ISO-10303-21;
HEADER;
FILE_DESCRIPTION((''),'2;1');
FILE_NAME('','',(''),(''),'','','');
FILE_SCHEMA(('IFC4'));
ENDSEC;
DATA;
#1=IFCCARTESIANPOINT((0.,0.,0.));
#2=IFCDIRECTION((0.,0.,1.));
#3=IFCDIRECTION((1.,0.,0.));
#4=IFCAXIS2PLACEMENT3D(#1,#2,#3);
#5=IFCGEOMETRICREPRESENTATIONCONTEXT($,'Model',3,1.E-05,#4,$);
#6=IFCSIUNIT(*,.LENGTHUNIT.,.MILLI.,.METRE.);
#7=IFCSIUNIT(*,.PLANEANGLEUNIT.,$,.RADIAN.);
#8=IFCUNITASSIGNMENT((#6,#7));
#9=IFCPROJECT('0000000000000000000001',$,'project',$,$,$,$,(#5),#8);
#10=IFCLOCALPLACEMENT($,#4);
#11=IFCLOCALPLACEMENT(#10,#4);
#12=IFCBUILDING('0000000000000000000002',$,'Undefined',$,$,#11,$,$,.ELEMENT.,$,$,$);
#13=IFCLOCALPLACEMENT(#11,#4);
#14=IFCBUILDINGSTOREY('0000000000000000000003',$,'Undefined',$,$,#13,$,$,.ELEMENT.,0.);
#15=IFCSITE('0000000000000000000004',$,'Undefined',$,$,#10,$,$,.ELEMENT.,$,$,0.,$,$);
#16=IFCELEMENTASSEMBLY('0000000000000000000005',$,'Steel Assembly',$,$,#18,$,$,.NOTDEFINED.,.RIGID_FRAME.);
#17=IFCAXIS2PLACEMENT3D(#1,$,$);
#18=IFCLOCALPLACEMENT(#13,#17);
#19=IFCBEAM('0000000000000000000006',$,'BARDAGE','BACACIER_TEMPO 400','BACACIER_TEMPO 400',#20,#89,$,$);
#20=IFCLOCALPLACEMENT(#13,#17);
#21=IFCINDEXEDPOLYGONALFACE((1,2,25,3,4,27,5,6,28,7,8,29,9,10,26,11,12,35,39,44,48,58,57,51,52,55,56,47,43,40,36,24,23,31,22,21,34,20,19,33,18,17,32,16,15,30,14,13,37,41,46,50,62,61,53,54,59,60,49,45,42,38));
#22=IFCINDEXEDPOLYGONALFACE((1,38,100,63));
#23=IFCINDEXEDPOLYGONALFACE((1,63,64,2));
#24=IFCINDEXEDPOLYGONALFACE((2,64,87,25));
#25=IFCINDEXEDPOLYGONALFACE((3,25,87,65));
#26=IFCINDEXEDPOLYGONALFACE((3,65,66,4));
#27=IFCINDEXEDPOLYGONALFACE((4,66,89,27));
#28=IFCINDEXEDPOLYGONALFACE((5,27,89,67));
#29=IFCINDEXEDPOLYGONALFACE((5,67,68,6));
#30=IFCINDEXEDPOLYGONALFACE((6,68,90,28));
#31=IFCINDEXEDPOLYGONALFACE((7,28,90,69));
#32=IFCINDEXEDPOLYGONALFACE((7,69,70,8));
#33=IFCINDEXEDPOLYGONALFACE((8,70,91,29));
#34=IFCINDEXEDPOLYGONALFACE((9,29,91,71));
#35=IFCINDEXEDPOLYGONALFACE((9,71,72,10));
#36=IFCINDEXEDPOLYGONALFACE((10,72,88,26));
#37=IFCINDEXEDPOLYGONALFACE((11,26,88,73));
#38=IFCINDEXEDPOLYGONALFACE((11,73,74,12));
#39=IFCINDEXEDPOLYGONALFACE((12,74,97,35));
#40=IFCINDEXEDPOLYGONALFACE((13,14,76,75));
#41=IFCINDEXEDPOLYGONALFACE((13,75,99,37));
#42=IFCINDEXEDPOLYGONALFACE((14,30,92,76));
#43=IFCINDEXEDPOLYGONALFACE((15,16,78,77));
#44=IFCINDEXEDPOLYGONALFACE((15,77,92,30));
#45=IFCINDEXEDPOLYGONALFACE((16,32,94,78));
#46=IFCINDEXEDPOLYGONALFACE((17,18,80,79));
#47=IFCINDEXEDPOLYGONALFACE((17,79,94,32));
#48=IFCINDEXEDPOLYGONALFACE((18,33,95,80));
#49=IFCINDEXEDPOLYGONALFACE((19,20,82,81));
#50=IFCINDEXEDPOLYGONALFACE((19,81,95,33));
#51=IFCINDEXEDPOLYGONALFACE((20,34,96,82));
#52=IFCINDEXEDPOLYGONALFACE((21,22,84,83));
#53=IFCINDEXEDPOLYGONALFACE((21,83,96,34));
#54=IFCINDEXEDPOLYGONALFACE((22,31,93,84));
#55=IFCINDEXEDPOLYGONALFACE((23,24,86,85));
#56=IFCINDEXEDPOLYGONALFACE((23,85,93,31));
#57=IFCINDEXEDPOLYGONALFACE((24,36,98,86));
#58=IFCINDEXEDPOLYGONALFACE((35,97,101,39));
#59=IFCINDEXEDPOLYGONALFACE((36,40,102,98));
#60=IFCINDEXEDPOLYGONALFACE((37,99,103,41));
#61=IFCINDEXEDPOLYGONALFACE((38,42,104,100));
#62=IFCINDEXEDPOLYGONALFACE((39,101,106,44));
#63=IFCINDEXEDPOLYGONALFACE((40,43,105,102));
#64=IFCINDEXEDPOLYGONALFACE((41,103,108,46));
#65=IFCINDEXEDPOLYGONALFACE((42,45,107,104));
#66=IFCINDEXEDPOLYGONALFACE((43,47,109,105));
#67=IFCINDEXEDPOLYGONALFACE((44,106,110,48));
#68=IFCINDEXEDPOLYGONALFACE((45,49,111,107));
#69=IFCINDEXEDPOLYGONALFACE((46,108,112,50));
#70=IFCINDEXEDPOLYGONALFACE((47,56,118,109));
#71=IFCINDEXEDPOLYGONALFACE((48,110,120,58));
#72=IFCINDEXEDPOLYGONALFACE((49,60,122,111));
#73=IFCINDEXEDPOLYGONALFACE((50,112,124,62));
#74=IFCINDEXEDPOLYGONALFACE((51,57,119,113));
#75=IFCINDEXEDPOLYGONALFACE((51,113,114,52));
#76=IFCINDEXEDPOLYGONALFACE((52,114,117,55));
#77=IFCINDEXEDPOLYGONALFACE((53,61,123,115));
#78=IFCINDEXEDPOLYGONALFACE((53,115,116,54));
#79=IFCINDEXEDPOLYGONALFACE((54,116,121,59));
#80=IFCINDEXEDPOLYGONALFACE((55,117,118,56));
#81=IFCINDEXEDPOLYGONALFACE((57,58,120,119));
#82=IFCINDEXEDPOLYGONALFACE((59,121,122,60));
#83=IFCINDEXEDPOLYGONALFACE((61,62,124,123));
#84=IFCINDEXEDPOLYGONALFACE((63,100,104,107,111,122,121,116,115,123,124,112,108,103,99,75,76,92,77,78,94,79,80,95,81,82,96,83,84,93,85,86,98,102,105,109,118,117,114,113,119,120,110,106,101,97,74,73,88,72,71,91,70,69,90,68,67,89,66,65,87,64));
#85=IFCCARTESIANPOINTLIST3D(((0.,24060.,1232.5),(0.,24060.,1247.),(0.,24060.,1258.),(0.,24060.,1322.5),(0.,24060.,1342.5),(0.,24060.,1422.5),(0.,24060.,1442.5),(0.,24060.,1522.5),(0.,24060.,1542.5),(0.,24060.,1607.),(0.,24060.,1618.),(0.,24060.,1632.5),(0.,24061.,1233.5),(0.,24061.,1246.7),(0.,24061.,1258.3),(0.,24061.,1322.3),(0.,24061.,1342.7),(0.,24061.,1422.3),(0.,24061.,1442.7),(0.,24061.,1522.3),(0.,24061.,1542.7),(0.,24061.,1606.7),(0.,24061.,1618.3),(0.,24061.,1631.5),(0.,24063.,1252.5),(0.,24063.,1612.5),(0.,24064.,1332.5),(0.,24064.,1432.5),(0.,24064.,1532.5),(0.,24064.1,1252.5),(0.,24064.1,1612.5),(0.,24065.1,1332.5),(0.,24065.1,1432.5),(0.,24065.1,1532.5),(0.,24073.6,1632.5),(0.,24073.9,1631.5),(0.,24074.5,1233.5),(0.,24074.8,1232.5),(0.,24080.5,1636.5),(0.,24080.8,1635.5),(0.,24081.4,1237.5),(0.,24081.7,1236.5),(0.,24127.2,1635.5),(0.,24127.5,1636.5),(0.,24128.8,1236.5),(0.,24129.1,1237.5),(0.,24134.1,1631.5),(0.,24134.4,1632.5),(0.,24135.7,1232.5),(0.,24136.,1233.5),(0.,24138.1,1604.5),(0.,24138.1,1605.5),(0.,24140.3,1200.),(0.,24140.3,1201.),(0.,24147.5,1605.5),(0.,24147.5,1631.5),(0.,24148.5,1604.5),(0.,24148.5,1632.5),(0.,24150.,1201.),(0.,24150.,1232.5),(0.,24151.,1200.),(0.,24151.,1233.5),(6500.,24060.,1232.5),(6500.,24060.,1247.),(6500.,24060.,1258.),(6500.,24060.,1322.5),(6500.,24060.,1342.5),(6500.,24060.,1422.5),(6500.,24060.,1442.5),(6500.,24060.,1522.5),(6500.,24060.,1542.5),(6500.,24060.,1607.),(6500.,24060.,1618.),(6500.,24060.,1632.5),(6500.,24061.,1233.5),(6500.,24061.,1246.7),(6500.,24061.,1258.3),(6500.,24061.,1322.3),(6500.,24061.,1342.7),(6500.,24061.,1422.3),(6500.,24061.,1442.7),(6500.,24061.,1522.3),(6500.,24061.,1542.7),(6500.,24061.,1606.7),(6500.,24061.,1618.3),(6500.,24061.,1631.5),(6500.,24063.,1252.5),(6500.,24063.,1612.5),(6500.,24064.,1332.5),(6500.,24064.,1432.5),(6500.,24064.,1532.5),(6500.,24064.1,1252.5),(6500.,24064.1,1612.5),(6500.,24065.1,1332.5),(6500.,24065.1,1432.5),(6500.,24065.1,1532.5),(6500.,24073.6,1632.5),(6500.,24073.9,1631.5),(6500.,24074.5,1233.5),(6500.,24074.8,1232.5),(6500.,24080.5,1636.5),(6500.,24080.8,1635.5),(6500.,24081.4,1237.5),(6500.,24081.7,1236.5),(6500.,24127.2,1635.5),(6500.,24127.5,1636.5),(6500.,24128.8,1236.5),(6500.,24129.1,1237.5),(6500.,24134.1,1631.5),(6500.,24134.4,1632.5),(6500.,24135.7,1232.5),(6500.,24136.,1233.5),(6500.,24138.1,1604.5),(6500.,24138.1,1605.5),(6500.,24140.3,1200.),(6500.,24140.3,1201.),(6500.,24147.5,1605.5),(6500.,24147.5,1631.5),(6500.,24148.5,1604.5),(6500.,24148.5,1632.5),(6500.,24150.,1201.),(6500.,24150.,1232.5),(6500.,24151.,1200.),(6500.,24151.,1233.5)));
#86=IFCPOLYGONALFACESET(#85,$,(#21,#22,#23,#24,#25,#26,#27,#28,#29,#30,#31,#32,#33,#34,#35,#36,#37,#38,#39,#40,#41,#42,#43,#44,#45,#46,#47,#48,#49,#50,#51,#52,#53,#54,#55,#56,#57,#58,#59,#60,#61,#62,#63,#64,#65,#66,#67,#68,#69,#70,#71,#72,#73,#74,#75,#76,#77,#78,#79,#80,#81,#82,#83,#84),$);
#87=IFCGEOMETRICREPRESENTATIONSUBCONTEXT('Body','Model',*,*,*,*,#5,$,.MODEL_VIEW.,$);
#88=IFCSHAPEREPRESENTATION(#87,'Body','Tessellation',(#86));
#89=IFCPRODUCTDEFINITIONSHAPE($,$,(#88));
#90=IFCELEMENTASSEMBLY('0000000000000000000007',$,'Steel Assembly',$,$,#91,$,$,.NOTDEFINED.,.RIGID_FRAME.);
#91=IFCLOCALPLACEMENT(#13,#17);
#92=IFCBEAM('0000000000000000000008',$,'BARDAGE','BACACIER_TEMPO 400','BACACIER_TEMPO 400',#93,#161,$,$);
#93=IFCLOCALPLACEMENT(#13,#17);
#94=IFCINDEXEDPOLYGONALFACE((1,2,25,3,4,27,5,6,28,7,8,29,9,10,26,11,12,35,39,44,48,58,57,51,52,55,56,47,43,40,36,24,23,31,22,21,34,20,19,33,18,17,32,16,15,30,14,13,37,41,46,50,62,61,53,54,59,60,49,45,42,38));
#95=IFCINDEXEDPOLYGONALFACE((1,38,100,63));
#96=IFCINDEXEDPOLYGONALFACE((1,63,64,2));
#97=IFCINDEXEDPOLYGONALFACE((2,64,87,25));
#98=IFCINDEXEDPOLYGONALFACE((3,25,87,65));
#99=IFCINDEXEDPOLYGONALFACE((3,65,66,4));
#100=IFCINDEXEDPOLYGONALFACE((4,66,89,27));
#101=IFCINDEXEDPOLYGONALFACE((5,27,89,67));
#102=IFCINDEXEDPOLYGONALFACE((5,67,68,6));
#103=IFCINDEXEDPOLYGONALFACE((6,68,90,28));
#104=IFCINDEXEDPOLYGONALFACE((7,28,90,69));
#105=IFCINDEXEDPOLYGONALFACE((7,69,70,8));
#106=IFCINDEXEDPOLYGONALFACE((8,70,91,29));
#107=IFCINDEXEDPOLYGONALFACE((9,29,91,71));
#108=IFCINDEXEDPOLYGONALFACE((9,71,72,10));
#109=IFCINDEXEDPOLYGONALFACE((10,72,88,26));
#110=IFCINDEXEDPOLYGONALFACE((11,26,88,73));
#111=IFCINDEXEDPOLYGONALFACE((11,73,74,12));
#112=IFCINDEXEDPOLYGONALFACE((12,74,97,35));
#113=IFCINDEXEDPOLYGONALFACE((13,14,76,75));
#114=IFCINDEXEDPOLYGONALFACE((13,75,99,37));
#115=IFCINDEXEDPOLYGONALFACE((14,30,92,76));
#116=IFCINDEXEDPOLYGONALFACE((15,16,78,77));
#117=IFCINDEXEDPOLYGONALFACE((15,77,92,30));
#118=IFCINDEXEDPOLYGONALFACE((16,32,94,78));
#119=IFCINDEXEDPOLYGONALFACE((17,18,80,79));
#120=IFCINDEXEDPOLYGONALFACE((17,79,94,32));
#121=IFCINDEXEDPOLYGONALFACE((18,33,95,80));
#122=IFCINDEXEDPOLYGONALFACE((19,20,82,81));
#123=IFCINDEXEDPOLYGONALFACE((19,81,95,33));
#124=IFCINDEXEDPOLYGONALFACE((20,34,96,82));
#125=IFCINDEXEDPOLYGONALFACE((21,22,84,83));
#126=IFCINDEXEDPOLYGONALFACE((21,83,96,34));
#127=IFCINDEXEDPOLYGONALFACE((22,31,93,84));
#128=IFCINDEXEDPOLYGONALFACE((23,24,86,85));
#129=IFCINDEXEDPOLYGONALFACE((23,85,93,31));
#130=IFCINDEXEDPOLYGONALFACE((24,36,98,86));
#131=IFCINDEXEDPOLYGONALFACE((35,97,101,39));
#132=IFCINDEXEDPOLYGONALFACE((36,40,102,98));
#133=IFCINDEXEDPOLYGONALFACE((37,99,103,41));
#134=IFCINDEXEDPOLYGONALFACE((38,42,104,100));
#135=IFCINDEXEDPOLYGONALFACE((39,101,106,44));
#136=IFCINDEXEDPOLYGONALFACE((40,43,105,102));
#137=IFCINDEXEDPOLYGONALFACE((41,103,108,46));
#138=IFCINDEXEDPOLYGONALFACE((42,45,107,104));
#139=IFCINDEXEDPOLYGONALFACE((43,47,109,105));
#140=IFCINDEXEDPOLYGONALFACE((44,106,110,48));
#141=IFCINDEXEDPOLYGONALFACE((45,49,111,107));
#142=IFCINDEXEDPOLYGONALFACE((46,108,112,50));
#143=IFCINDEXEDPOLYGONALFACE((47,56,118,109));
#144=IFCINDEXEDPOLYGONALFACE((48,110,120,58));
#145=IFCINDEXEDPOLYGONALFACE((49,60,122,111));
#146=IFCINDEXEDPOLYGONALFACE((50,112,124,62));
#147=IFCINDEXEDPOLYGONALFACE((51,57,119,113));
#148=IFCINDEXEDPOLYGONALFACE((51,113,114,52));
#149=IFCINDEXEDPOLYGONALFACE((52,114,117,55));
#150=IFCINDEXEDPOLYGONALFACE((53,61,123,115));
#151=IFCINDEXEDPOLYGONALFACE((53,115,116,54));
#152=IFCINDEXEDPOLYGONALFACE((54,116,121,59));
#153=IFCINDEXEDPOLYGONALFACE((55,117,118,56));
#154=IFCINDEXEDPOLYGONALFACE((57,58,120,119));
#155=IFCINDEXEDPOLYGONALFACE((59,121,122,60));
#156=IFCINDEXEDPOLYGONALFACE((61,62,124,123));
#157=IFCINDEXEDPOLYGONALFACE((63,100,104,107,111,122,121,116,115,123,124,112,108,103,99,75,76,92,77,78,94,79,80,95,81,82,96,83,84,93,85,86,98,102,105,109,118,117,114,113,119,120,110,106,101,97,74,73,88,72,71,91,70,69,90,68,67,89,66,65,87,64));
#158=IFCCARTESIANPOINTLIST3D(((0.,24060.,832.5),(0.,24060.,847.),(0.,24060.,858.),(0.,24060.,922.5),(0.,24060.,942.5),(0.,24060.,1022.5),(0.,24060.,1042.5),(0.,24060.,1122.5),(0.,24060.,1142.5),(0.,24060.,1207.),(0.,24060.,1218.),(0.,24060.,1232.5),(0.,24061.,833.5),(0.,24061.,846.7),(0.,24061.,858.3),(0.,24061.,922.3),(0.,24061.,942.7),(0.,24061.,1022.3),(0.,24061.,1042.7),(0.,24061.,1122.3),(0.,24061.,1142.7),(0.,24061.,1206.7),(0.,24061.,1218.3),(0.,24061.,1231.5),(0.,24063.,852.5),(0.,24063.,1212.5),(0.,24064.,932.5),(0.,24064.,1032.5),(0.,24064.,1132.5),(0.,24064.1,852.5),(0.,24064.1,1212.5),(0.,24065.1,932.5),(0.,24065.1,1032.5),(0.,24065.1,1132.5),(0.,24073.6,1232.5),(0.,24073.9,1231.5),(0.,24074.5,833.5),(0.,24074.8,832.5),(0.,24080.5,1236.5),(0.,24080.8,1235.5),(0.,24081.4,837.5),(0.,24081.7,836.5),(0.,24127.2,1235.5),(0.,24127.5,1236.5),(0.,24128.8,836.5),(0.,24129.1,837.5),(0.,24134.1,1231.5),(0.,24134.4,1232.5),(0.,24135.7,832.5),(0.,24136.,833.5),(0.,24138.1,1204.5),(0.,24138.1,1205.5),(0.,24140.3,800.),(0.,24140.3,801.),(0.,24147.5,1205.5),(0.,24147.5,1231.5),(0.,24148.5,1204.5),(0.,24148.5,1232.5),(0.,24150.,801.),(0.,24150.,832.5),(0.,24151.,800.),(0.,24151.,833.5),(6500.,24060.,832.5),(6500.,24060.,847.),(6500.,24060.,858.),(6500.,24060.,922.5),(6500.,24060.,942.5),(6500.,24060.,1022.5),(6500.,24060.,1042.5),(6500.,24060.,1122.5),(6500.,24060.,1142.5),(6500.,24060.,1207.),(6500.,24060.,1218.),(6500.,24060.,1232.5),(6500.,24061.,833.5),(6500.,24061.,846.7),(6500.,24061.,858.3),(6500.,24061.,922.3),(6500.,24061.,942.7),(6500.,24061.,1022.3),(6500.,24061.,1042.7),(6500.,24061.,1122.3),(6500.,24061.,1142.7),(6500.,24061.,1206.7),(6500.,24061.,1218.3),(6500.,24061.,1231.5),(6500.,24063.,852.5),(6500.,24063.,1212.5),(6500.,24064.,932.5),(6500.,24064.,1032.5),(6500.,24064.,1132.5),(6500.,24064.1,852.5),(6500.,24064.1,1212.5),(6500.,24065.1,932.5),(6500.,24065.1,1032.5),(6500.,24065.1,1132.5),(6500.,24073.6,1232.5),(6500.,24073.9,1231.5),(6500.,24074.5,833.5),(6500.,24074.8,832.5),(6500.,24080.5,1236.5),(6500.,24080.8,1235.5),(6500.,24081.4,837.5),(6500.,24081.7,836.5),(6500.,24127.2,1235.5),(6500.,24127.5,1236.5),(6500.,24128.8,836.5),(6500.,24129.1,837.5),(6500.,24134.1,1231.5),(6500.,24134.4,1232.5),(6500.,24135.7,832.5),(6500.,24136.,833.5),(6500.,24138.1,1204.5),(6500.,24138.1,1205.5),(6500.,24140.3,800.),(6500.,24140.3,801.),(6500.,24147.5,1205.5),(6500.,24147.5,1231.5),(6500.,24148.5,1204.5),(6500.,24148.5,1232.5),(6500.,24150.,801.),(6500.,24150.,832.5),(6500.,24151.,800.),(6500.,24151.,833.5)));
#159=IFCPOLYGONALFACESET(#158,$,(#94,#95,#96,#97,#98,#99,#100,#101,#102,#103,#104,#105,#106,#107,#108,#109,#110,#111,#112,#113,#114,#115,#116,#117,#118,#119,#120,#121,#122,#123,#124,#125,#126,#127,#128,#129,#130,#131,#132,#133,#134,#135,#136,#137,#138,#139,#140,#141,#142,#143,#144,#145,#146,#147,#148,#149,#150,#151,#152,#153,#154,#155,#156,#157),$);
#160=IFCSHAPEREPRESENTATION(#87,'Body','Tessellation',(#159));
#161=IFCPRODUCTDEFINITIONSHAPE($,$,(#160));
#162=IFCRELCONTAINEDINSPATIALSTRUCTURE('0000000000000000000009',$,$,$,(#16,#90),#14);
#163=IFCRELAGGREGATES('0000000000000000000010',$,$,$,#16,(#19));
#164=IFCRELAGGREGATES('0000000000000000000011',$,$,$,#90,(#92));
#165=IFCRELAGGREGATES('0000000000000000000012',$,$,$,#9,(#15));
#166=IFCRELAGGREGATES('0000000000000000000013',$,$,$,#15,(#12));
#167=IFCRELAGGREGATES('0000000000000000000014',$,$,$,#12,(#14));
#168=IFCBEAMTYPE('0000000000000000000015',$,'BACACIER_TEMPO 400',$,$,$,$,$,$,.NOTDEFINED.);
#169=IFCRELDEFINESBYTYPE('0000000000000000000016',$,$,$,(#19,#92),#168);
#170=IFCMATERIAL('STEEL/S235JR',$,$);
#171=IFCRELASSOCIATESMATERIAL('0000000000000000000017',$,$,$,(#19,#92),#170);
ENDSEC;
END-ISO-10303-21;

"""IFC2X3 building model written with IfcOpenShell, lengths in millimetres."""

from ifc_helpers import new_model, si_unit, frame, origin_with_axes, place, context, subcontext, project, spatial, polyline, outline, extrude, material, type_object, element, aggregate, save


model = new_model("IFC2X3")

# Units and contexts
model_context = context("Model", 3, precision=1e-05, world=origin_with_axes())
body_context = subcontext(model_context, "Body", "Model", "MODEL_VIEW")
ifc_project = project(units=[si_unit("LENGTHUNIT", "METRE", prefix="MILLI"), si_unit("PLANEANGLEUNIT", "RADIAN")], contexts=[model_context])

# Site, building, storey
site_placement = place(None, origin_with_axes())
site = spatial("IfcSite", under=ifc_project, at=site_placement, Name="Undefined", CompositionType="ELEMENT", RefElevation=0.0)
building_placement = place(site_placement, origin_with_axes())
building = spatial("IfcBuilding", under=site, at=building_placement, Name="Undefined", CompositionType="ELEMENT")
storey_placement = place(building_placement, origin_with_axes())
storey = spatial("IfcBuildingStorey", under=building, at=storey_placement, Name="Undefined", CompositionType="ELEMENT", Elevation=0.0)

# Element assemblies, beams
ifc_material_1 = material(Name="STEEL/S235JR")
beam_type_1 = type_object("IfcBeamType", Name="BACACIER_TEMPO 400", PredefinedType="NOTDEFINED")
assembly_1_placement = place(storey_placement, origin_with_axes())
assembly_1 = element("IfcElementAssembly", 1, at=assembly_1_placement, inside=storey, Name="Steel Assembly", AssemblyPlace="NOTDEFINED", PredefinedType="RIGID_FRAME")
beam_1_placement = place(assembly_1_placement, frame((0.0, 24105.5, 1418.2), z_axis=(0.0, 1.0, 0.0), x_axis=(1.0, 0.0, 0.0)))
beam_1 = element("IfcBeam", 2, at=beam_1_placement, type_object=beam_type_1, material=ifc_material_1, Name="BARDAGE", Description="BACACIER_TEMPO 400", ObjectType="BACACIER_TEMPO 400", context=body_context, shape_type="SweptSolid", body=[
    extrude(outline(polyline([(218.2, -25.0), (214.2, -31.9), (214.2, -45.5), (199.8, -45.5), (194.2, -42.5), (188.8, -45.5), (124.2, -45.5), (114.2, -41.5), (104.2, -45.5), (24.2, -45.5), (14.2, -41.5), (4.2, -45.5), (-75.8, -45.5), (-85.8, -41.5), (-95.8, -45.5), (-160.2, -45.5), (-165.8, -42.5), (-171.2, -45.5), (-185.8, -45.5), (-185.8, -30.7), (-181.8, -23.8), (-181.8, 23.3), (-185.8, 30.2), (-185.8, 44.5), (-217.2, 44.5), (-217.2, 34.8), (-218.2, 34.8), (-218.2, 45.5), (-184.8, 45.5), (-184.8, 30.5), (-180.8, 23.6), (-180.8, -24.1), (-184.8, -31.0), (-184.8, -44.5), (-171.5, -44.5), (-165.8, -41.4), (-160.0, -44.5), (-95.9, -44.5), (-85.8, -40.4), (-75.6, -44.5), (4.1, -44.5), (14.2, -40.4), (24.4, -44.5), (104.1, -44.5), (114.2, -40.4), (124.4, -44.5), (188.5, -44.5), (194.2, -41.4), (200.0, -44.5), (213.2, -44.5), (213.2, -31.6), (217.2, -24.7), (217.2, 21.7), (213.2, 28.6), (213.2, 42.0), (187.2, 42.0), (187.2, 32.5), (186.2, 32.5), (186.2, 43.0), (214.2, 43.0), (214.2, 28.9), (218.2, 22.0), (218.2, -25.0)])), frame((6500.0, 0.0, 0.0), z_axis=(-1.0, 0.0, 0.0), x_axis=(0.0, -1.0, 0.0)), (0.0, 0.0, 1.0), 6500.0),
])
aggregate(assembly_1, [beam_1])
assembly_2_placement = place(storey_placement, origin_with_axes())
assembly_2 = element("IfcElementAssembly", 3, at=assembly_2_placement, inside=storey, Name="Steel Assembly", AssemblyPlace="NOTDEFINED", PredefinedType="RIGID_FRAME")
beam_2_placement = place(assembly_2_placement, frame((0.0, 24105.5, 1018.2), z_axis=(0.0, 1.0, 0.0), x_axis=(1.0, 0.0, 0.0)))
beam_2 = element("IfcBeam", 4, at=beam_2_placement, type_object=beam_type_1, material=ifc_material_1, Name="BARDAGE", Description="BACACIER_TEMPO 400", ObjectType="BACACIER_TEMPO 400", context=body_context, shape_type="SweptSolid", body=[
    extrude(outline(polyline([(218.2, -25.0), (214.2, -31.9), (214.2, -45.5), (199.8, -45.5), (194.2, -42.5), (188.8, -45.5), (124.2, -45.5), (114.2, -41.5), (104.2, -45.5), (24.2, -45.5), (14.2, -41.5), (4.2, -45.5), (-75.8, -45.5), (-85.8, -41.5), (-95.8, -45.5), (-160.2, -45.5), (-165.8, -42.5), (-171.2, -45.5), (-185.8, -45.5), (-185.8, -30.7), (-181.8, -23.8), (-181.8, 23.3), (-185.8, 30.2), (-185.8, 44.5), (-217.2, 44.5), (-217.2, 34.8), (-218.2, 34.8), (-218.2, 45.5), (-184.8, 45.5), (-184.8, 30.5), (-180.8, 23.6), (-180.8, -24.1), (-184.8, -31.0), (-184.8, -44.5), (-171.5, -44.5), (-165.8, -41.4), (-160.0, -44.5), (-95.9, -44.5), (-85.8, -40.4), (-75.6, -44.5), (4.1, -44.5), (14.2, -40.4), (24.4, -44.5), (104.1, -44.5), (114.2, -40.4), (124.4, -44.5), (188.5, -44.5), (194.2, -41.4), (200.0, -44.5), (213.2, -44.5), (213.2, -31.6), (217.2, -24.7), (217.2, 21.7), (213.2, 28.6), (213.2, 42.0), (187.2, 42.0), (187.2, 32.5), (186.2, 32.5), (186.2, 43.0), (214.2, 43.0), (214.2, 28.9), (218.2, 22.0), (218.2, -25.0)])), frame((6500.0, 0.0, 0.0), z_axis=(-1.0, 0.0, 0.0), x_axis=(0.0, -1.0, 0.0)), (0.0, 0.0, 1.0), 6500.0),
])
aggregate(assembly_2, [beam_2])

save(model, "model.ifc")
